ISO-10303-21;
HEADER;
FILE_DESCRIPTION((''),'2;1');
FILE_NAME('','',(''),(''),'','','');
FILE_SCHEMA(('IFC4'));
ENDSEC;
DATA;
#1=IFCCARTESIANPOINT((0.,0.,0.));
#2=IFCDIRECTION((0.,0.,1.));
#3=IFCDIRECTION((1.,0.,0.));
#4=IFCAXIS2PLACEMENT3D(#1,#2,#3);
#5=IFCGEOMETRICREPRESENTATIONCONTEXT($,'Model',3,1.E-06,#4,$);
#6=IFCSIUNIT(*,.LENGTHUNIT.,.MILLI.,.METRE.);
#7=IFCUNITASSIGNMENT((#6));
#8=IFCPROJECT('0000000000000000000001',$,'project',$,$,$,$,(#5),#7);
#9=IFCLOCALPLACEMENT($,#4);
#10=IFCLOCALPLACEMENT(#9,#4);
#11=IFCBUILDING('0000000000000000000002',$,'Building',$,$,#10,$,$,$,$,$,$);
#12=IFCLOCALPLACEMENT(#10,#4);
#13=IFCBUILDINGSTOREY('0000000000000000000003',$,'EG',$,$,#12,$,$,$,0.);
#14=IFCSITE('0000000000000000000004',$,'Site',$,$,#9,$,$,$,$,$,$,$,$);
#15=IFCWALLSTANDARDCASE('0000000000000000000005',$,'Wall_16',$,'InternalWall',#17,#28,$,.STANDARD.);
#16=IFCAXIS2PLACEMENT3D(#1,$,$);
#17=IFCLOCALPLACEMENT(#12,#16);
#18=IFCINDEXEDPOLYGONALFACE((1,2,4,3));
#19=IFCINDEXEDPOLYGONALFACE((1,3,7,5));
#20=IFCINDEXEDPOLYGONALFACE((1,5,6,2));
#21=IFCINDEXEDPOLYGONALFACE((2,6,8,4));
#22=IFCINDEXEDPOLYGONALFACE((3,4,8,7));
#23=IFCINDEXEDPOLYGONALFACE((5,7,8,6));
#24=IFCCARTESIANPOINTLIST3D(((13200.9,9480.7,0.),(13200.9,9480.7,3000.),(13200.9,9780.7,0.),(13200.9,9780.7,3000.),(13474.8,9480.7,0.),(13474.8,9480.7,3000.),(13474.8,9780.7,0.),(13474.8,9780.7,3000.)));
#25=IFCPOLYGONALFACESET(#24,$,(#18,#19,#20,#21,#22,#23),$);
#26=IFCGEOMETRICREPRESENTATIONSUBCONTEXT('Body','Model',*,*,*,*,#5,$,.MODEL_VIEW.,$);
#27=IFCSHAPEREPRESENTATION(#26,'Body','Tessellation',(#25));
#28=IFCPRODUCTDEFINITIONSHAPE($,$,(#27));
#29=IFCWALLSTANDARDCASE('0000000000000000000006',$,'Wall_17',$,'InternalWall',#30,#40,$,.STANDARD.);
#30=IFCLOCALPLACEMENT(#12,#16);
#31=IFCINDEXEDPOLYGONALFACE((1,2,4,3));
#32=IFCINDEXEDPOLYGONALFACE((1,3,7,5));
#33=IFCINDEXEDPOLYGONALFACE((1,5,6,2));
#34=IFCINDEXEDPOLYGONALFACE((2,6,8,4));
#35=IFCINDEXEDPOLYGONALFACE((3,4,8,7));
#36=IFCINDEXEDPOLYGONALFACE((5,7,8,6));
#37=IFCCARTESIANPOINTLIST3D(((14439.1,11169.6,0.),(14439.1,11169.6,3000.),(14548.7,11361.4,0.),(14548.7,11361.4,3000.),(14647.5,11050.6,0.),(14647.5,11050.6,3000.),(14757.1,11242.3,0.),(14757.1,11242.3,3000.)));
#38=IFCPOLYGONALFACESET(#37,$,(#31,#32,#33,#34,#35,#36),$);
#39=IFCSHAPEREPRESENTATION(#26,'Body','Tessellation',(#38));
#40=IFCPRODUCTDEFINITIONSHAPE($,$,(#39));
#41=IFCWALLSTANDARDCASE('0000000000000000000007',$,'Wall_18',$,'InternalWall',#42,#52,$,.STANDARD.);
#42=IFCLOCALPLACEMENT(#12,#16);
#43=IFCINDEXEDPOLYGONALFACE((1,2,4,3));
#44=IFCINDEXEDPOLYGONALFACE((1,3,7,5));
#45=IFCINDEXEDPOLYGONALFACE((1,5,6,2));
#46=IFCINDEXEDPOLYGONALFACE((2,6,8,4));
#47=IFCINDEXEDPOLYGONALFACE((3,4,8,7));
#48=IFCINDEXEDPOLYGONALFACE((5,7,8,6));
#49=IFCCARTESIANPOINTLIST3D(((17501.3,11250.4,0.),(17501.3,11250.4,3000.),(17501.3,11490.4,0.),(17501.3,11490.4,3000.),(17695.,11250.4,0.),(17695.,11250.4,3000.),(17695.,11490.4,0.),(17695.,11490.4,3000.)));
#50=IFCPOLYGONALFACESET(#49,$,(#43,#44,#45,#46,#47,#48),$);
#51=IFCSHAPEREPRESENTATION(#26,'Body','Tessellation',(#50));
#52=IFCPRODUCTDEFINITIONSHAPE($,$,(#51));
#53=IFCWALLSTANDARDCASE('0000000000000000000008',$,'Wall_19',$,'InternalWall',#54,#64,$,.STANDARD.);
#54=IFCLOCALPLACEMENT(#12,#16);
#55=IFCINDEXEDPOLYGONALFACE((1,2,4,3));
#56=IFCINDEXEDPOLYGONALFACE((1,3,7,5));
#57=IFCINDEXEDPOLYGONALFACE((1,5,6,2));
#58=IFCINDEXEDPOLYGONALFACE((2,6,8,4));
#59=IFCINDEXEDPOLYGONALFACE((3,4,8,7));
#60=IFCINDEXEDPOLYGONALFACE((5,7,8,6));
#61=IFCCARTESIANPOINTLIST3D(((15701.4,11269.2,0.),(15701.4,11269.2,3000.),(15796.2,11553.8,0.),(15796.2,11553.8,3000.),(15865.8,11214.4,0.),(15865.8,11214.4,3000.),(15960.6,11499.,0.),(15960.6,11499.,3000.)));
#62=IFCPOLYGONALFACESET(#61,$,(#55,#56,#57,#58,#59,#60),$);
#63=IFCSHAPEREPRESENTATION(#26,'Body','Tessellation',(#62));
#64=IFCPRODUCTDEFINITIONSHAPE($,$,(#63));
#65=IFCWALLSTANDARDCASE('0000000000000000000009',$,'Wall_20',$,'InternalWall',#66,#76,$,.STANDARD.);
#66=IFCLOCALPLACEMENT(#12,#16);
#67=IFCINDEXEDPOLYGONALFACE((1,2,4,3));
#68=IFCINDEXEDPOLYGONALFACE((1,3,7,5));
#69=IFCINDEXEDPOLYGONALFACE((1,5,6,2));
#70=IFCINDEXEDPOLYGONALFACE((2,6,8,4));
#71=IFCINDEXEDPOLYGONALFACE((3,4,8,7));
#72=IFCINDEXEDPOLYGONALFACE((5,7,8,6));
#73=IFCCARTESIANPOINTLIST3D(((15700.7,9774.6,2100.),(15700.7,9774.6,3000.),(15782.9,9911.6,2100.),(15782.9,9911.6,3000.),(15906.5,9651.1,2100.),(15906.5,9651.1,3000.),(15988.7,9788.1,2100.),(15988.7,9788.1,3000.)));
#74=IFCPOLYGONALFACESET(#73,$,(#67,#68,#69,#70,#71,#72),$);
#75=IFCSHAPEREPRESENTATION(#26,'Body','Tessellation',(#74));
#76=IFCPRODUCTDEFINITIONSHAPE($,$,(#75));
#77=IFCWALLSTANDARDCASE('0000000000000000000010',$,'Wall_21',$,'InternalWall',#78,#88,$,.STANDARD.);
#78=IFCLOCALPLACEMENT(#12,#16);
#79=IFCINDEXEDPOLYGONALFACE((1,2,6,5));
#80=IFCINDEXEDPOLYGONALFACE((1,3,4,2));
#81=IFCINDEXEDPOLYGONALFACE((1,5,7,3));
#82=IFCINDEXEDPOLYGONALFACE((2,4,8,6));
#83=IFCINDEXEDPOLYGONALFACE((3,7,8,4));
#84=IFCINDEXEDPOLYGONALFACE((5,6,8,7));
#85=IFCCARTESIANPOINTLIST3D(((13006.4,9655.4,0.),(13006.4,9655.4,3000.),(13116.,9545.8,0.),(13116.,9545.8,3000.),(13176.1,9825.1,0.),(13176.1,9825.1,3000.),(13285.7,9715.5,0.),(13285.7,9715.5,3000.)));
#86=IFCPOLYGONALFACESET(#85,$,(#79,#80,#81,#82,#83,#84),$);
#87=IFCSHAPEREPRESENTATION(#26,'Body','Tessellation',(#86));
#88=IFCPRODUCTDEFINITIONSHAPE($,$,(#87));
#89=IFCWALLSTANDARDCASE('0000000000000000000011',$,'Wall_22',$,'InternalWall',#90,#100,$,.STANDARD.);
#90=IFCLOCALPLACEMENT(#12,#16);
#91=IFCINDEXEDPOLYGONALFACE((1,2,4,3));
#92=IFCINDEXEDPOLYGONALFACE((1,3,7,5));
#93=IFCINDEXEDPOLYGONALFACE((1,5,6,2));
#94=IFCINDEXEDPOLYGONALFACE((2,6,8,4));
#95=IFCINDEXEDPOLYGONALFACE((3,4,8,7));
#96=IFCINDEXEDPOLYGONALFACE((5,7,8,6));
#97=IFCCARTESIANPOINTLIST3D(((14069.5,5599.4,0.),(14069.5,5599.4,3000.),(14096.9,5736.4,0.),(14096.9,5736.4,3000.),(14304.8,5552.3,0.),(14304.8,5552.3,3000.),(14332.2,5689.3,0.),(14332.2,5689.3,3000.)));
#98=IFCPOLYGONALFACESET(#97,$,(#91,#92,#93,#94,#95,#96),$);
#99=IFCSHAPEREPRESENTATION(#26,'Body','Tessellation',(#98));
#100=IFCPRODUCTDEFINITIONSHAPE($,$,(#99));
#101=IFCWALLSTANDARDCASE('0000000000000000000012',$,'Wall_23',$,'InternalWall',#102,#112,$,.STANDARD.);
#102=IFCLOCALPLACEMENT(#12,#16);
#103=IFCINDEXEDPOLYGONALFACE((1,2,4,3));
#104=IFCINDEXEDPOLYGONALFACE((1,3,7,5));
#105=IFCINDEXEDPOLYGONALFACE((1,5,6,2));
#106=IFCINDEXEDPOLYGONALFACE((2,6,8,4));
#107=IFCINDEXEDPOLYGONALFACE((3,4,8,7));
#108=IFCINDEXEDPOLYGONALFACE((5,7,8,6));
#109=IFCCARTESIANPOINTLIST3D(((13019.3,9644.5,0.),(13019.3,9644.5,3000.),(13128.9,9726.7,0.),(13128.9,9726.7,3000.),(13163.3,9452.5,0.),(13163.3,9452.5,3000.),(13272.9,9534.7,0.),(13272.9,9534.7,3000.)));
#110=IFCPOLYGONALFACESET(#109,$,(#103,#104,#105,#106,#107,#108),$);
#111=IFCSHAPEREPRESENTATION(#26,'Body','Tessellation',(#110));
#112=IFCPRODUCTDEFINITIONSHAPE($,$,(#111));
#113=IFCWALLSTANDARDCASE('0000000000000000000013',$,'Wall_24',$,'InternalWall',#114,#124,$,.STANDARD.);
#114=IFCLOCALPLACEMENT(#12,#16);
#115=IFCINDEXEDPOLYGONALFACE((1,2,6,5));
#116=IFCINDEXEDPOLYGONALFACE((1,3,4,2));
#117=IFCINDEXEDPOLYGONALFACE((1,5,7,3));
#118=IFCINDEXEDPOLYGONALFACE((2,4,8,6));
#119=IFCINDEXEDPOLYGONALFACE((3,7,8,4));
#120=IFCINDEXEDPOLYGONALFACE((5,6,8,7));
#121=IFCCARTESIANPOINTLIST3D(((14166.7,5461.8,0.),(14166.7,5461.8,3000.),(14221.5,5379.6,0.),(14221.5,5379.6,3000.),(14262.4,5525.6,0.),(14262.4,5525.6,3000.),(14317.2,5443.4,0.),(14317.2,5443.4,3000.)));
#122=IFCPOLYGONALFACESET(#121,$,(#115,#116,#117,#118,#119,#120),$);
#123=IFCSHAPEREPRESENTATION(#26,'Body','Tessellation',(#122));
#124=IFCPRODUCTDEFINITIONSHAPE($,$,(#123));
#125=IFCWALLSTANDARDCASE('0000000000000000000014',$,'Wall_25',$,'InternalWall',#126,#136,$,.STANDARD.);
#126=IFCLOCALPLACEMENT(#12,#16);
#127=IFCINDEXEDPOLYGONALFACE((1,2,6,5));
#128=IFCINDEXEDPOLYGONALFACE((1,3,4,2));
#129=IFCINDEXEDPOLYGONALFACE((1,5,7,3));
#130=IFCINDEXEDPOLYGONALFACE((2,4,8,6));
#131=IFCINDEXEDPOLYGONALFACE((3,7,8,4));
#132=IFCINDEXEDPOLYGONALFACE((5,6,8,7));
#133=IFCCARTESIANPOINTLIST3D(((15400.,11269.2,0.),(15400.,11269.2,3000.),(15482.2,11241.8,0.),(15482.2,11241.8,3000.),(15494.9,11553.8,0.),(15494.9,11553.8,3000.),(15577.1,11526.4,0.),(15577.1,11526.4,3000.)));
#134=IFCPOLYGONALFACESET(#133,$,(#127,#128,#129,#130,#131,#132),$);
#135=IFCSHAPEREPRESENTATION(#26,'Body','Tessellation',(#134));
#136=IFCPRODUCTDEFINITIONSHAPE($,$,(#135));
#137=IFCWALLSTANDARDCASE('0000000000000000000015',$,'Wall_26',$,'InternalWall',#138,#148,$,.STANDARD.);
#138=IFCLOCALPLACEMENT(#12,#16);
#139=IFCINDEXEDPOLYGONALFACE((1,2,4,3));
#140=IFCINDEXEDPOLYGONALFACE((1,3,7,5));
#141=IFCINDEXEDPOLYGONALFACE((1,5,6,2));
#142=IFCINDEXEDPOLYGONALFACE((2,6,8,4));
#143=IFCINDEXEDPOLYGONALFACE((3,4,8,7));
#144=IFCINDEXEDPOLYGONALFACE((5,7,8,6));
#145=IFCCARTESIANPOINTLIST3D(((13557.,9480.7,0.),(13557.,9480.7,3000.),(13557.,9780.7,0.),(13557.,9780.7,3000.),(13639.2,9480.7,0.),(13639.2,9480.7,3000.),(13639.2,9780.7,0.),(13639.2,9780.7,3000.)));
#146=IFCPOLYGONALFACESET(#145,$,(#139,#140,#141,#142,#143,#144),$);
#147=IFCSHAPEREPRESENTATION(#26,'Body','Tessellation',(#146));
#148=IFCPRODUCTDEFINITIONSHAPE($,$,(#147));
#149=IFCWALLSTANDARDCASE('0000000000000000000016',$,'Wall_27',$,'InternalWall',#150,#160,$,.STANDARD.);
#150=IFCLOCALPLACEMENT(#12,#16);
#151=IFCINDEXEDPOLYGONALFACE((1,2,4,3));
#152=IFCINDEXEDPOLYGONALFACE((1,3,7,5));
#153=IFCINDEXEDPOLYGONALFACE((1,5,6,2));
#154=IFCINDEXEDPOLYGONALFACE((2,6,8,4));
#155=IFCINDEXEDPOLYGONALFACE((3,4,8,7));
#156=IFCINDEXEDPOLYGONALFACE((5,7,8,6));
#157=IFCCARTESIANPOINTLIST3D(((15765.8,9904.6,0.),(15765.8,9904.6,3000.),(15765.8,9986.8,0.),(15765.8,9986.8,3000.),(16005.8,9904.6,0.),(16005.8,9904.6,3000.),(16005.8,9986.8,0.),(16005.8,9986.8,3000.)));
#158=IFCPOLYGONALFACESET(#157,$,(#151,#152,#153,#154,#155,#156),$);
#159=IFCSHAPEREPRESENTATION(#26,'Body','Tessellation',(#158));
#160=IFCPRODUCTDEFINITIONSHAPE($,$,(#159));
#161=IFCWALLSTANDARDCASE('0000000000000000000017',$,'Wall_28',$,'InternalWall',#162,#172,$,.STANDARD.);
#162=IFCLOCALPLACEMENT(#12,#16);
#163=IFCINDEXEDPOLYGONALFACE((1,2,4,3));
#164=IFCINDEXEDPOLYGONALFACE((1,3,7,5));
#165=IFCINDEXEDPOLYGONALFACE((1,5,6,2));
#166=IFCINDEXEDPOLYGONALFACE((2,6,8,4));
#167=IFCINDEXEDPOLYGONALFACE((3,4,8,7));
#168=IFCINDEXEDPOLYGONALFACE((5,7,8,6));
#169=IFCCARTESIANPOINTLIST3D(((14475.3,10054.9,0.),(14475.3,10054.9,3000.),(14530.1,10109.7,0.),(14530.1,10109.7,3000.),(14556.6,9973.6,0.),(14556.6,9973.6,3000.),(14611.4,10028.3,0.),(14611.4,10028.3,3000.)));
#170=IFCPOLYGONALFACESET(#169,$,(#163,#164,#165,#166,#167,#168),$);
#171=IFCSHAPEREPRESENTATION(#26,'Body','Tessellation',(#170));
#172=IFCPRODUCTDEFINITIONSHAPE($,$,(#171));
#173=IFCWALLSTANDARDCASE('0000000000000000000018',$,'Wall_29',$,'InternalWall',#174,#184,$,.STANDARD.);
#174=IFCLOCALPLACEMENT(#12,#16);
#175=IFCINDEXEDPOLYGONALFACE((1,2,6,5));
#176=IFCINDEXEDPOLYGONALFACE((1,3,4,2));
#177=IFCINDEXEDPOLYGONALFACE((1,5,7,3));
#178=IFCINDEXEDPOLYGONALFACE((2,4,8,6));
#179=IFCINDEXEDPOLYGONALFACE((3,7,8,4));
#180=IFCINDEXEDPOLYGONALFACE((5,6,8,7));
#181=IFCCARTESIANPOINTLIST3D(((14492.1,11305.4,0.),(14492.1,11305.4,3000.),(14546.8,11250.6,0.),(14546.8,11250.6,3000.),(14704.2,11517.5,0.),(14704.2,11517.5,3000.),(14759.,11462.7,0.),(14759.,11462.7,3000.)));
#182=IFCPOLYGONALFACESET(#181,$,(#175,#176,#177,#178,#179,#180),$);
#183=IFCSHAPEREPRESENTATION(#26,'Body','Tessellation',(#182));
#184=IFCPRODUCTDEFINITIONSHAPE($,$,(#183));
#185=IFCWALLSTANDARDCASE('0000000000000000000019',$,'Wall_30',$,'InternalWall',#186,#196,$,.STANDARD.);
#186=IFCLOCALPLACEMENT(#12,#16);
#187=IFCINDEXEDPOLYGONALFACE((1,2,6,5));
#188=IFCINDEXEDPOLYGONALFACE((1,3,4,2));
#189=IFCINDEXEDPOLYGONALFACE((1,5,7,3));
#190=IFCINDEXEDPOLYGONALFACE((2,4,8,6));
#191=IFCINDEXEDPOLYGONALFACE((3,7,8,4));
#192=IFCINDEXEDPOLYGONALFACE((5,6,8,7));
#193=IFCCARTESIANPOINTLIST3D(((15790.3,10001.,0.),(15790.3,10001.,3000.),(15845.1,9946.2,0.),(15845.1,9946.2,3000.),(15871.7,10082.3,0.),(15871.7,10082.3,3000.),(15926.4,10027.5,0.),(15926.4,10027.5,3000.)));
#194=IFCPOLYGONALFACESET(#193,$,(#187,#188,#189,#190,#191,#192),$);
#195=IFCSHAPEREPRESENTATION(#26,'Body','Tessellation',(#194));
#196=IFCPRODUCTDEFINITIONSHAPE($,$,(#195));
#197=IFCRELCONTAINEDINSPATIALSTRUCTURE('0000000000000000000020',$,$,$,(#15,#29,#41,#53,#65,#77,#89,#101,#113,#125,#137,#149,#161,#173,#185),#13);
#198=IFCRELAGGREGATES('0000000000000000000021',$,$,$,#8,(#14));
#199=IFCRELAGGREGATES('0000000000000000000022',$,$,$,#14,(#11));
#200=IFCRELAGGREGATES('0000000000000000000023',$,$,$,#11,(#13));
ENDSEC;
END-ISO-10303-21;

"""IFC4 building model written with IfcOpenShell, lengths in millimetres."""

from ifc_helpers import new_model, si_unit, frame, origin_with_axes, place, context, subcontext, project, spatial, rectangle, extrude, element, save


model = new_model("IFC4")

# Units and contexts
model_context = context("Model", 3, precision=1e-06, world=origin_with_axes())
body_context = subcontext(model_context, "Body", "Model", "MODEL_VIEW")
ifc_project = project(units=[si_unit("LENGTHUNIT", "METRE", prefix="MILLI")], contexts=[model_context])

# Site, building, storey
site_placement = place(None, origin_with_axes())
site = spatial("IfcSite", under=ifc_project, at=site_placement, Name="Site")
building_placement = place(site_placement, origin_with_axes())
building = spatial("IfcBuilding", under=site, at=building_placement, Name="Building")
storey_placement = place(building_placement, origin_with_axes())
storey = spatial("IfcBuildingStorey", under=building, at=storey_placement, Name="EG", Elevation=0.0)

# Walls
wall_1_placement = place(storey_placement, origin_with_axes())
element("IfcWallStandardCase", 1, at=wall_1_placement, inside=storey, Name="Wall_16", ObjectType="InternalWall", PredefinedType="STANDARD", context=body_context, shape_type="SweptSolid", body=[
    extrude(rectangle(XDim=274.0, YDim=300.0), frame((13337.8, 9630.7, 0.0), z_axis=(0.0, 0.0, 1.0), x_axis=(-1.0, 0.0, 0.0)), (0.0, 0.0, 1.0), 3000.0),
])
wall_2_placement = place(storey_placement, origin_with_axes())
element("IfcWallStandardCase", 2, at=wall_2_placement, inside=storey, Name="Wall_17", ObjectType="InternalWall", PredefinedType="STANDARD", context=body_context, shape_type="SweptSolid", body=[
    extrude(rectangle(XDim=220.9, YDim=240.0), frame((14598.1, 11206.0, 0.0), z_axis=(0.0, 0.0, 1.0), x_axis=(-0.496139, -0.868243, 0.0)), (0.0, 0.0, 1.0), 3000.0),
])
wall_3_placement = place(storey_placement, origin_with_axes())
element("IfcWallStandardCase", 3, at=wall_3_placement, inside=storey, Name="Wall_18", ObjectType="InternalWall", PredefinedType="STANDARD", context=body_context, shape_type="SweptSolid", body=[
    extrude(rectangle(XDim=193.7, YDim=240.0), frame((17598.1, 11370.4, 0.0), z_axis=(0.0, 0.0, 1.0), x_axis=(1.0, 0.0, 0.0)), (0.0, 0.0, 1.0), 3000.0),
])
wall_4_placement = place(storey_placement, origin_with_axes())
element("IfcWallStandardCase", 4, at=wall_4_placement, inside=storey, Name="Wall_19", ObjectType="InternalWall", PredefinedType="STANDARD", context=body_context, shape_type="SweptSolid", body=[
    extrude(rectangle(XDim=173.3, YDim=300.0), frame((15831.0, 11384.1, 0.0), z_axis=(0.0, 0.0, 1.0), x_axis=(0.948683, -0.316228, 0.0)), (0.0, 0.0, 1.0), 3000.0),
])

# Wall, opening
wall_5_placement = place(storey_placement, origin_with_axes())
wall_5 = element("IfcWallStandardCase", 5, at=wall_5_placement, inside=storey, Name="Wall_20", ObjectType="InternalWall", PredefinedType="STANDARD", context=body_context, shape_type="SweptSolid", body=[
    extrude(rectangle(XDim=159.8, YDim=240.0), frame((15844.7, 9781.3, 0.0), z_axis=(0.0, 0.0, 1.0), x_axis=(0.514496, 0.857493, 0.0)), (0.0, 0.0, 1.0), 3000.0),
])
opening_1_placement = place(wall_5_placement, origin_with_axes())
element("IfcOpeningElement", 6, at=opening_1_placement, inside=storey, cuts=wall_5, context=body_context, shape_type="SweptSolid", body=[
    extrude(rectangle(XDim=1706.2, YDim=240.0), frame((15684.1, 9513.7, 0.0), z_axis=(0.0, 0.0, 1.0), x_axis=(0.514496, 0.857493, 0.0)), (0.0, 0.0, 1.0), 2100.0),
])

# Walls
wall_6_placement = place(storey_placement, origin_with_axes())
element("IfcWallStandardCase", 7, at=wall_6_placement, inside=storey, Name="Wall_21", ObjectType="InternalWall", PredefinedType="STANDARD", context=body_context, shape_type="SweptSolid", body=[
    extrude(rectangle(XDim=155.0, YDim=240.0), frame((13146.1, 9685.4, 0.0), z_axis=(0.0, 0.0, 1.0), x_axis=(-0.707107, 0.707107, 0.0)), (0.0, 0.0, 1.0), 3000.0),
])
wall_7_placement = place(storey_placement, origin_with_axes())
element("IfcWallStandardCase", 8, at=wall_7_placement, inside=storey, Name="Wall_22", ObjectType="InternalWall", PredefinedType="STANDARD", context=body_context, shape_type="SweptSolid", body=[
    extrude(rectangle(XDim=139.7, YDim=240.0), frame((14200.9, 5644.3, 0.0), z_axis=(0.0, 0.0, 1.0), x_axis=(-0.196116, -0.980581, 0.0)), (0.0, 0.0, 1.0), 3000.0),
])
wall_8_placement = place(storey_placement, origin_with_axes())
element("IfcWallStandardCase", 9, at=wall_8_placement, inside=storey, Name="Wall_23", ObjectType="InternalWall", PredefinedType="STANDARD", context=body_context, shape_type="SweptSolid", body=[
    extrude(rectangle(XDim=137.0, YDim=240.0), frame((13146.1, 9589.6, 0.0), z_axis=(0.0, 0.0, 1.0), x_axis=(-0.8, -0.6, 0.0)), (0.0, 0.0, 1.0), 3000.0),
])
wall_9_placement = place(storey_placement, origin_with_axes())
element("IfcWallStandardCase", 10, at=wall_9_placement, inside=storey, Name="Wall_24", ObjectType="InternalWall", PredefinedType="STANDARD", context=body_context, shape_type="SweptSolid", body=[
    extrude(rectangle(XDim=98.8, YDim=115.0), frame((14242.0, 5452.6, 0.0), z_axis=(0.0, 0.0, 1.0), x_axis=(0.5547, -0.83205, 0.0)), (0.0, 0.0, 1.0), 3000.0),
])
wall_10_placement = place(storey_placement, origin_with_axes())
element("IfcWallStandardCase", 11, at=wall_10_placement, inside=storey, Name="Wall_25", ObjectType="InternalWall", PredefinedType="STANDARD", context=body_context, shape_type="SweptSolid", body=[
    extrude(rectangle(XDim=86.6, YDim=300.0), frame((15488.5, 11397.8, 0.0), z_axis=(0.0, 0.0, 1.0), x_axis=(0.948683, -0.316228, 0.0)), (0.0, 0.0, 1.0), 3000.0),
])
wall_11_placement = place(storey_placement, origin_with_axes())
element("IfcWallStandardCase", 12, at=wall_11_placement, inside=storey, Name="Wall_26", ObjectType="InternalWall", PredefinedType="STANDARD", context=body_context, shape_type="SweptSolid", body=[
    extrude(rectangle(XDim=82.2, YDim=300.0), frame((13598.1, 9630.7, 0.0), z_axis=(0.0, 0.0, 1.0), x_axis=(-1.0, 0.0, 0.0)), (0.0, 0.0, 1.0), 3000.0),
])
wall_12_placement = place(storey_placement, origin_with_axes())
element("IfcWallStandardCase", 13, at=wall_12_placement, inside=storey, Name="Wall_27", ObjectType="InternalWall", PredefinedType="STANDARD", context=body_context, shape_type="SweptSolid", body=[
    extrude(rectangle(XDim=82.2, YDim=240.0), frame((15885.8, 9945.7, 0.0), z_axis=(0.0, 0.0, 1.0), x_axis=(0.0, 1.0, 0.0)), (0.0, 0.0, 1.0), 3000.0),
])
wall_13_placement = place(storey_placement, origin_with_axes())
element("IfcWallStandardCase", 14, at=wall_13_placement, inside=storey, Name="Wall_28", ObjectType="InternalWall", PredefinedType="STANDARD", context=body_context, shape_type="SweptSolid", body=[
    extrude(rectangle(XDim=77.5, YDim=115.0), frame((14543.3, 10041.6, 0.0), z_axis=(0.0, 0.0, 1.0), x_axis=(0.707107, 0.707107, 0.0)), (0.0, 0.0, 1.0), 3000.0),
])
wall_14_placement = place(storey_placement, origin_with_axes())
element("IfcWallStandardCase", 15, at=wall_14_placement, inside=storey, Name="Wall_29", ObjectType="InternalWall", PredefinedType="STANDARD", context=body_context, shape_type="SweptSolid", body=[
    extrude(rectangle(XDim=77.5, YDim=300.0), frame((14625.5, 11384.1, 0.0), z_axis=(0.0, 0.0, 1.0), x_axis=(-0.707107, 0.707107, 0.0)), (0.0, 0.0, 1.0), 3000.0),
])
wall_15_placement = place(storey_placement, origin_with_axes())
element("IfcWallStandardCase", 16, at=wall_15_placement, inside=storey, Name="Wall_30", ObjectType="InternalWall", PredefinedType="STANDARD", context=body_context, shape_type="SweptSolid", body=[
    extrude(rectangle(XDim=77.5, YDim=115.0), frame((15858.4, 10014.2, 0.0), z_axis=(0.0, 0.0, 1.0), x_axis=(-0.707107, 0.707107, 0.0)), (0.0, 0.0, 1.0), 3000.0),
])

save(model, "model.ifc")
